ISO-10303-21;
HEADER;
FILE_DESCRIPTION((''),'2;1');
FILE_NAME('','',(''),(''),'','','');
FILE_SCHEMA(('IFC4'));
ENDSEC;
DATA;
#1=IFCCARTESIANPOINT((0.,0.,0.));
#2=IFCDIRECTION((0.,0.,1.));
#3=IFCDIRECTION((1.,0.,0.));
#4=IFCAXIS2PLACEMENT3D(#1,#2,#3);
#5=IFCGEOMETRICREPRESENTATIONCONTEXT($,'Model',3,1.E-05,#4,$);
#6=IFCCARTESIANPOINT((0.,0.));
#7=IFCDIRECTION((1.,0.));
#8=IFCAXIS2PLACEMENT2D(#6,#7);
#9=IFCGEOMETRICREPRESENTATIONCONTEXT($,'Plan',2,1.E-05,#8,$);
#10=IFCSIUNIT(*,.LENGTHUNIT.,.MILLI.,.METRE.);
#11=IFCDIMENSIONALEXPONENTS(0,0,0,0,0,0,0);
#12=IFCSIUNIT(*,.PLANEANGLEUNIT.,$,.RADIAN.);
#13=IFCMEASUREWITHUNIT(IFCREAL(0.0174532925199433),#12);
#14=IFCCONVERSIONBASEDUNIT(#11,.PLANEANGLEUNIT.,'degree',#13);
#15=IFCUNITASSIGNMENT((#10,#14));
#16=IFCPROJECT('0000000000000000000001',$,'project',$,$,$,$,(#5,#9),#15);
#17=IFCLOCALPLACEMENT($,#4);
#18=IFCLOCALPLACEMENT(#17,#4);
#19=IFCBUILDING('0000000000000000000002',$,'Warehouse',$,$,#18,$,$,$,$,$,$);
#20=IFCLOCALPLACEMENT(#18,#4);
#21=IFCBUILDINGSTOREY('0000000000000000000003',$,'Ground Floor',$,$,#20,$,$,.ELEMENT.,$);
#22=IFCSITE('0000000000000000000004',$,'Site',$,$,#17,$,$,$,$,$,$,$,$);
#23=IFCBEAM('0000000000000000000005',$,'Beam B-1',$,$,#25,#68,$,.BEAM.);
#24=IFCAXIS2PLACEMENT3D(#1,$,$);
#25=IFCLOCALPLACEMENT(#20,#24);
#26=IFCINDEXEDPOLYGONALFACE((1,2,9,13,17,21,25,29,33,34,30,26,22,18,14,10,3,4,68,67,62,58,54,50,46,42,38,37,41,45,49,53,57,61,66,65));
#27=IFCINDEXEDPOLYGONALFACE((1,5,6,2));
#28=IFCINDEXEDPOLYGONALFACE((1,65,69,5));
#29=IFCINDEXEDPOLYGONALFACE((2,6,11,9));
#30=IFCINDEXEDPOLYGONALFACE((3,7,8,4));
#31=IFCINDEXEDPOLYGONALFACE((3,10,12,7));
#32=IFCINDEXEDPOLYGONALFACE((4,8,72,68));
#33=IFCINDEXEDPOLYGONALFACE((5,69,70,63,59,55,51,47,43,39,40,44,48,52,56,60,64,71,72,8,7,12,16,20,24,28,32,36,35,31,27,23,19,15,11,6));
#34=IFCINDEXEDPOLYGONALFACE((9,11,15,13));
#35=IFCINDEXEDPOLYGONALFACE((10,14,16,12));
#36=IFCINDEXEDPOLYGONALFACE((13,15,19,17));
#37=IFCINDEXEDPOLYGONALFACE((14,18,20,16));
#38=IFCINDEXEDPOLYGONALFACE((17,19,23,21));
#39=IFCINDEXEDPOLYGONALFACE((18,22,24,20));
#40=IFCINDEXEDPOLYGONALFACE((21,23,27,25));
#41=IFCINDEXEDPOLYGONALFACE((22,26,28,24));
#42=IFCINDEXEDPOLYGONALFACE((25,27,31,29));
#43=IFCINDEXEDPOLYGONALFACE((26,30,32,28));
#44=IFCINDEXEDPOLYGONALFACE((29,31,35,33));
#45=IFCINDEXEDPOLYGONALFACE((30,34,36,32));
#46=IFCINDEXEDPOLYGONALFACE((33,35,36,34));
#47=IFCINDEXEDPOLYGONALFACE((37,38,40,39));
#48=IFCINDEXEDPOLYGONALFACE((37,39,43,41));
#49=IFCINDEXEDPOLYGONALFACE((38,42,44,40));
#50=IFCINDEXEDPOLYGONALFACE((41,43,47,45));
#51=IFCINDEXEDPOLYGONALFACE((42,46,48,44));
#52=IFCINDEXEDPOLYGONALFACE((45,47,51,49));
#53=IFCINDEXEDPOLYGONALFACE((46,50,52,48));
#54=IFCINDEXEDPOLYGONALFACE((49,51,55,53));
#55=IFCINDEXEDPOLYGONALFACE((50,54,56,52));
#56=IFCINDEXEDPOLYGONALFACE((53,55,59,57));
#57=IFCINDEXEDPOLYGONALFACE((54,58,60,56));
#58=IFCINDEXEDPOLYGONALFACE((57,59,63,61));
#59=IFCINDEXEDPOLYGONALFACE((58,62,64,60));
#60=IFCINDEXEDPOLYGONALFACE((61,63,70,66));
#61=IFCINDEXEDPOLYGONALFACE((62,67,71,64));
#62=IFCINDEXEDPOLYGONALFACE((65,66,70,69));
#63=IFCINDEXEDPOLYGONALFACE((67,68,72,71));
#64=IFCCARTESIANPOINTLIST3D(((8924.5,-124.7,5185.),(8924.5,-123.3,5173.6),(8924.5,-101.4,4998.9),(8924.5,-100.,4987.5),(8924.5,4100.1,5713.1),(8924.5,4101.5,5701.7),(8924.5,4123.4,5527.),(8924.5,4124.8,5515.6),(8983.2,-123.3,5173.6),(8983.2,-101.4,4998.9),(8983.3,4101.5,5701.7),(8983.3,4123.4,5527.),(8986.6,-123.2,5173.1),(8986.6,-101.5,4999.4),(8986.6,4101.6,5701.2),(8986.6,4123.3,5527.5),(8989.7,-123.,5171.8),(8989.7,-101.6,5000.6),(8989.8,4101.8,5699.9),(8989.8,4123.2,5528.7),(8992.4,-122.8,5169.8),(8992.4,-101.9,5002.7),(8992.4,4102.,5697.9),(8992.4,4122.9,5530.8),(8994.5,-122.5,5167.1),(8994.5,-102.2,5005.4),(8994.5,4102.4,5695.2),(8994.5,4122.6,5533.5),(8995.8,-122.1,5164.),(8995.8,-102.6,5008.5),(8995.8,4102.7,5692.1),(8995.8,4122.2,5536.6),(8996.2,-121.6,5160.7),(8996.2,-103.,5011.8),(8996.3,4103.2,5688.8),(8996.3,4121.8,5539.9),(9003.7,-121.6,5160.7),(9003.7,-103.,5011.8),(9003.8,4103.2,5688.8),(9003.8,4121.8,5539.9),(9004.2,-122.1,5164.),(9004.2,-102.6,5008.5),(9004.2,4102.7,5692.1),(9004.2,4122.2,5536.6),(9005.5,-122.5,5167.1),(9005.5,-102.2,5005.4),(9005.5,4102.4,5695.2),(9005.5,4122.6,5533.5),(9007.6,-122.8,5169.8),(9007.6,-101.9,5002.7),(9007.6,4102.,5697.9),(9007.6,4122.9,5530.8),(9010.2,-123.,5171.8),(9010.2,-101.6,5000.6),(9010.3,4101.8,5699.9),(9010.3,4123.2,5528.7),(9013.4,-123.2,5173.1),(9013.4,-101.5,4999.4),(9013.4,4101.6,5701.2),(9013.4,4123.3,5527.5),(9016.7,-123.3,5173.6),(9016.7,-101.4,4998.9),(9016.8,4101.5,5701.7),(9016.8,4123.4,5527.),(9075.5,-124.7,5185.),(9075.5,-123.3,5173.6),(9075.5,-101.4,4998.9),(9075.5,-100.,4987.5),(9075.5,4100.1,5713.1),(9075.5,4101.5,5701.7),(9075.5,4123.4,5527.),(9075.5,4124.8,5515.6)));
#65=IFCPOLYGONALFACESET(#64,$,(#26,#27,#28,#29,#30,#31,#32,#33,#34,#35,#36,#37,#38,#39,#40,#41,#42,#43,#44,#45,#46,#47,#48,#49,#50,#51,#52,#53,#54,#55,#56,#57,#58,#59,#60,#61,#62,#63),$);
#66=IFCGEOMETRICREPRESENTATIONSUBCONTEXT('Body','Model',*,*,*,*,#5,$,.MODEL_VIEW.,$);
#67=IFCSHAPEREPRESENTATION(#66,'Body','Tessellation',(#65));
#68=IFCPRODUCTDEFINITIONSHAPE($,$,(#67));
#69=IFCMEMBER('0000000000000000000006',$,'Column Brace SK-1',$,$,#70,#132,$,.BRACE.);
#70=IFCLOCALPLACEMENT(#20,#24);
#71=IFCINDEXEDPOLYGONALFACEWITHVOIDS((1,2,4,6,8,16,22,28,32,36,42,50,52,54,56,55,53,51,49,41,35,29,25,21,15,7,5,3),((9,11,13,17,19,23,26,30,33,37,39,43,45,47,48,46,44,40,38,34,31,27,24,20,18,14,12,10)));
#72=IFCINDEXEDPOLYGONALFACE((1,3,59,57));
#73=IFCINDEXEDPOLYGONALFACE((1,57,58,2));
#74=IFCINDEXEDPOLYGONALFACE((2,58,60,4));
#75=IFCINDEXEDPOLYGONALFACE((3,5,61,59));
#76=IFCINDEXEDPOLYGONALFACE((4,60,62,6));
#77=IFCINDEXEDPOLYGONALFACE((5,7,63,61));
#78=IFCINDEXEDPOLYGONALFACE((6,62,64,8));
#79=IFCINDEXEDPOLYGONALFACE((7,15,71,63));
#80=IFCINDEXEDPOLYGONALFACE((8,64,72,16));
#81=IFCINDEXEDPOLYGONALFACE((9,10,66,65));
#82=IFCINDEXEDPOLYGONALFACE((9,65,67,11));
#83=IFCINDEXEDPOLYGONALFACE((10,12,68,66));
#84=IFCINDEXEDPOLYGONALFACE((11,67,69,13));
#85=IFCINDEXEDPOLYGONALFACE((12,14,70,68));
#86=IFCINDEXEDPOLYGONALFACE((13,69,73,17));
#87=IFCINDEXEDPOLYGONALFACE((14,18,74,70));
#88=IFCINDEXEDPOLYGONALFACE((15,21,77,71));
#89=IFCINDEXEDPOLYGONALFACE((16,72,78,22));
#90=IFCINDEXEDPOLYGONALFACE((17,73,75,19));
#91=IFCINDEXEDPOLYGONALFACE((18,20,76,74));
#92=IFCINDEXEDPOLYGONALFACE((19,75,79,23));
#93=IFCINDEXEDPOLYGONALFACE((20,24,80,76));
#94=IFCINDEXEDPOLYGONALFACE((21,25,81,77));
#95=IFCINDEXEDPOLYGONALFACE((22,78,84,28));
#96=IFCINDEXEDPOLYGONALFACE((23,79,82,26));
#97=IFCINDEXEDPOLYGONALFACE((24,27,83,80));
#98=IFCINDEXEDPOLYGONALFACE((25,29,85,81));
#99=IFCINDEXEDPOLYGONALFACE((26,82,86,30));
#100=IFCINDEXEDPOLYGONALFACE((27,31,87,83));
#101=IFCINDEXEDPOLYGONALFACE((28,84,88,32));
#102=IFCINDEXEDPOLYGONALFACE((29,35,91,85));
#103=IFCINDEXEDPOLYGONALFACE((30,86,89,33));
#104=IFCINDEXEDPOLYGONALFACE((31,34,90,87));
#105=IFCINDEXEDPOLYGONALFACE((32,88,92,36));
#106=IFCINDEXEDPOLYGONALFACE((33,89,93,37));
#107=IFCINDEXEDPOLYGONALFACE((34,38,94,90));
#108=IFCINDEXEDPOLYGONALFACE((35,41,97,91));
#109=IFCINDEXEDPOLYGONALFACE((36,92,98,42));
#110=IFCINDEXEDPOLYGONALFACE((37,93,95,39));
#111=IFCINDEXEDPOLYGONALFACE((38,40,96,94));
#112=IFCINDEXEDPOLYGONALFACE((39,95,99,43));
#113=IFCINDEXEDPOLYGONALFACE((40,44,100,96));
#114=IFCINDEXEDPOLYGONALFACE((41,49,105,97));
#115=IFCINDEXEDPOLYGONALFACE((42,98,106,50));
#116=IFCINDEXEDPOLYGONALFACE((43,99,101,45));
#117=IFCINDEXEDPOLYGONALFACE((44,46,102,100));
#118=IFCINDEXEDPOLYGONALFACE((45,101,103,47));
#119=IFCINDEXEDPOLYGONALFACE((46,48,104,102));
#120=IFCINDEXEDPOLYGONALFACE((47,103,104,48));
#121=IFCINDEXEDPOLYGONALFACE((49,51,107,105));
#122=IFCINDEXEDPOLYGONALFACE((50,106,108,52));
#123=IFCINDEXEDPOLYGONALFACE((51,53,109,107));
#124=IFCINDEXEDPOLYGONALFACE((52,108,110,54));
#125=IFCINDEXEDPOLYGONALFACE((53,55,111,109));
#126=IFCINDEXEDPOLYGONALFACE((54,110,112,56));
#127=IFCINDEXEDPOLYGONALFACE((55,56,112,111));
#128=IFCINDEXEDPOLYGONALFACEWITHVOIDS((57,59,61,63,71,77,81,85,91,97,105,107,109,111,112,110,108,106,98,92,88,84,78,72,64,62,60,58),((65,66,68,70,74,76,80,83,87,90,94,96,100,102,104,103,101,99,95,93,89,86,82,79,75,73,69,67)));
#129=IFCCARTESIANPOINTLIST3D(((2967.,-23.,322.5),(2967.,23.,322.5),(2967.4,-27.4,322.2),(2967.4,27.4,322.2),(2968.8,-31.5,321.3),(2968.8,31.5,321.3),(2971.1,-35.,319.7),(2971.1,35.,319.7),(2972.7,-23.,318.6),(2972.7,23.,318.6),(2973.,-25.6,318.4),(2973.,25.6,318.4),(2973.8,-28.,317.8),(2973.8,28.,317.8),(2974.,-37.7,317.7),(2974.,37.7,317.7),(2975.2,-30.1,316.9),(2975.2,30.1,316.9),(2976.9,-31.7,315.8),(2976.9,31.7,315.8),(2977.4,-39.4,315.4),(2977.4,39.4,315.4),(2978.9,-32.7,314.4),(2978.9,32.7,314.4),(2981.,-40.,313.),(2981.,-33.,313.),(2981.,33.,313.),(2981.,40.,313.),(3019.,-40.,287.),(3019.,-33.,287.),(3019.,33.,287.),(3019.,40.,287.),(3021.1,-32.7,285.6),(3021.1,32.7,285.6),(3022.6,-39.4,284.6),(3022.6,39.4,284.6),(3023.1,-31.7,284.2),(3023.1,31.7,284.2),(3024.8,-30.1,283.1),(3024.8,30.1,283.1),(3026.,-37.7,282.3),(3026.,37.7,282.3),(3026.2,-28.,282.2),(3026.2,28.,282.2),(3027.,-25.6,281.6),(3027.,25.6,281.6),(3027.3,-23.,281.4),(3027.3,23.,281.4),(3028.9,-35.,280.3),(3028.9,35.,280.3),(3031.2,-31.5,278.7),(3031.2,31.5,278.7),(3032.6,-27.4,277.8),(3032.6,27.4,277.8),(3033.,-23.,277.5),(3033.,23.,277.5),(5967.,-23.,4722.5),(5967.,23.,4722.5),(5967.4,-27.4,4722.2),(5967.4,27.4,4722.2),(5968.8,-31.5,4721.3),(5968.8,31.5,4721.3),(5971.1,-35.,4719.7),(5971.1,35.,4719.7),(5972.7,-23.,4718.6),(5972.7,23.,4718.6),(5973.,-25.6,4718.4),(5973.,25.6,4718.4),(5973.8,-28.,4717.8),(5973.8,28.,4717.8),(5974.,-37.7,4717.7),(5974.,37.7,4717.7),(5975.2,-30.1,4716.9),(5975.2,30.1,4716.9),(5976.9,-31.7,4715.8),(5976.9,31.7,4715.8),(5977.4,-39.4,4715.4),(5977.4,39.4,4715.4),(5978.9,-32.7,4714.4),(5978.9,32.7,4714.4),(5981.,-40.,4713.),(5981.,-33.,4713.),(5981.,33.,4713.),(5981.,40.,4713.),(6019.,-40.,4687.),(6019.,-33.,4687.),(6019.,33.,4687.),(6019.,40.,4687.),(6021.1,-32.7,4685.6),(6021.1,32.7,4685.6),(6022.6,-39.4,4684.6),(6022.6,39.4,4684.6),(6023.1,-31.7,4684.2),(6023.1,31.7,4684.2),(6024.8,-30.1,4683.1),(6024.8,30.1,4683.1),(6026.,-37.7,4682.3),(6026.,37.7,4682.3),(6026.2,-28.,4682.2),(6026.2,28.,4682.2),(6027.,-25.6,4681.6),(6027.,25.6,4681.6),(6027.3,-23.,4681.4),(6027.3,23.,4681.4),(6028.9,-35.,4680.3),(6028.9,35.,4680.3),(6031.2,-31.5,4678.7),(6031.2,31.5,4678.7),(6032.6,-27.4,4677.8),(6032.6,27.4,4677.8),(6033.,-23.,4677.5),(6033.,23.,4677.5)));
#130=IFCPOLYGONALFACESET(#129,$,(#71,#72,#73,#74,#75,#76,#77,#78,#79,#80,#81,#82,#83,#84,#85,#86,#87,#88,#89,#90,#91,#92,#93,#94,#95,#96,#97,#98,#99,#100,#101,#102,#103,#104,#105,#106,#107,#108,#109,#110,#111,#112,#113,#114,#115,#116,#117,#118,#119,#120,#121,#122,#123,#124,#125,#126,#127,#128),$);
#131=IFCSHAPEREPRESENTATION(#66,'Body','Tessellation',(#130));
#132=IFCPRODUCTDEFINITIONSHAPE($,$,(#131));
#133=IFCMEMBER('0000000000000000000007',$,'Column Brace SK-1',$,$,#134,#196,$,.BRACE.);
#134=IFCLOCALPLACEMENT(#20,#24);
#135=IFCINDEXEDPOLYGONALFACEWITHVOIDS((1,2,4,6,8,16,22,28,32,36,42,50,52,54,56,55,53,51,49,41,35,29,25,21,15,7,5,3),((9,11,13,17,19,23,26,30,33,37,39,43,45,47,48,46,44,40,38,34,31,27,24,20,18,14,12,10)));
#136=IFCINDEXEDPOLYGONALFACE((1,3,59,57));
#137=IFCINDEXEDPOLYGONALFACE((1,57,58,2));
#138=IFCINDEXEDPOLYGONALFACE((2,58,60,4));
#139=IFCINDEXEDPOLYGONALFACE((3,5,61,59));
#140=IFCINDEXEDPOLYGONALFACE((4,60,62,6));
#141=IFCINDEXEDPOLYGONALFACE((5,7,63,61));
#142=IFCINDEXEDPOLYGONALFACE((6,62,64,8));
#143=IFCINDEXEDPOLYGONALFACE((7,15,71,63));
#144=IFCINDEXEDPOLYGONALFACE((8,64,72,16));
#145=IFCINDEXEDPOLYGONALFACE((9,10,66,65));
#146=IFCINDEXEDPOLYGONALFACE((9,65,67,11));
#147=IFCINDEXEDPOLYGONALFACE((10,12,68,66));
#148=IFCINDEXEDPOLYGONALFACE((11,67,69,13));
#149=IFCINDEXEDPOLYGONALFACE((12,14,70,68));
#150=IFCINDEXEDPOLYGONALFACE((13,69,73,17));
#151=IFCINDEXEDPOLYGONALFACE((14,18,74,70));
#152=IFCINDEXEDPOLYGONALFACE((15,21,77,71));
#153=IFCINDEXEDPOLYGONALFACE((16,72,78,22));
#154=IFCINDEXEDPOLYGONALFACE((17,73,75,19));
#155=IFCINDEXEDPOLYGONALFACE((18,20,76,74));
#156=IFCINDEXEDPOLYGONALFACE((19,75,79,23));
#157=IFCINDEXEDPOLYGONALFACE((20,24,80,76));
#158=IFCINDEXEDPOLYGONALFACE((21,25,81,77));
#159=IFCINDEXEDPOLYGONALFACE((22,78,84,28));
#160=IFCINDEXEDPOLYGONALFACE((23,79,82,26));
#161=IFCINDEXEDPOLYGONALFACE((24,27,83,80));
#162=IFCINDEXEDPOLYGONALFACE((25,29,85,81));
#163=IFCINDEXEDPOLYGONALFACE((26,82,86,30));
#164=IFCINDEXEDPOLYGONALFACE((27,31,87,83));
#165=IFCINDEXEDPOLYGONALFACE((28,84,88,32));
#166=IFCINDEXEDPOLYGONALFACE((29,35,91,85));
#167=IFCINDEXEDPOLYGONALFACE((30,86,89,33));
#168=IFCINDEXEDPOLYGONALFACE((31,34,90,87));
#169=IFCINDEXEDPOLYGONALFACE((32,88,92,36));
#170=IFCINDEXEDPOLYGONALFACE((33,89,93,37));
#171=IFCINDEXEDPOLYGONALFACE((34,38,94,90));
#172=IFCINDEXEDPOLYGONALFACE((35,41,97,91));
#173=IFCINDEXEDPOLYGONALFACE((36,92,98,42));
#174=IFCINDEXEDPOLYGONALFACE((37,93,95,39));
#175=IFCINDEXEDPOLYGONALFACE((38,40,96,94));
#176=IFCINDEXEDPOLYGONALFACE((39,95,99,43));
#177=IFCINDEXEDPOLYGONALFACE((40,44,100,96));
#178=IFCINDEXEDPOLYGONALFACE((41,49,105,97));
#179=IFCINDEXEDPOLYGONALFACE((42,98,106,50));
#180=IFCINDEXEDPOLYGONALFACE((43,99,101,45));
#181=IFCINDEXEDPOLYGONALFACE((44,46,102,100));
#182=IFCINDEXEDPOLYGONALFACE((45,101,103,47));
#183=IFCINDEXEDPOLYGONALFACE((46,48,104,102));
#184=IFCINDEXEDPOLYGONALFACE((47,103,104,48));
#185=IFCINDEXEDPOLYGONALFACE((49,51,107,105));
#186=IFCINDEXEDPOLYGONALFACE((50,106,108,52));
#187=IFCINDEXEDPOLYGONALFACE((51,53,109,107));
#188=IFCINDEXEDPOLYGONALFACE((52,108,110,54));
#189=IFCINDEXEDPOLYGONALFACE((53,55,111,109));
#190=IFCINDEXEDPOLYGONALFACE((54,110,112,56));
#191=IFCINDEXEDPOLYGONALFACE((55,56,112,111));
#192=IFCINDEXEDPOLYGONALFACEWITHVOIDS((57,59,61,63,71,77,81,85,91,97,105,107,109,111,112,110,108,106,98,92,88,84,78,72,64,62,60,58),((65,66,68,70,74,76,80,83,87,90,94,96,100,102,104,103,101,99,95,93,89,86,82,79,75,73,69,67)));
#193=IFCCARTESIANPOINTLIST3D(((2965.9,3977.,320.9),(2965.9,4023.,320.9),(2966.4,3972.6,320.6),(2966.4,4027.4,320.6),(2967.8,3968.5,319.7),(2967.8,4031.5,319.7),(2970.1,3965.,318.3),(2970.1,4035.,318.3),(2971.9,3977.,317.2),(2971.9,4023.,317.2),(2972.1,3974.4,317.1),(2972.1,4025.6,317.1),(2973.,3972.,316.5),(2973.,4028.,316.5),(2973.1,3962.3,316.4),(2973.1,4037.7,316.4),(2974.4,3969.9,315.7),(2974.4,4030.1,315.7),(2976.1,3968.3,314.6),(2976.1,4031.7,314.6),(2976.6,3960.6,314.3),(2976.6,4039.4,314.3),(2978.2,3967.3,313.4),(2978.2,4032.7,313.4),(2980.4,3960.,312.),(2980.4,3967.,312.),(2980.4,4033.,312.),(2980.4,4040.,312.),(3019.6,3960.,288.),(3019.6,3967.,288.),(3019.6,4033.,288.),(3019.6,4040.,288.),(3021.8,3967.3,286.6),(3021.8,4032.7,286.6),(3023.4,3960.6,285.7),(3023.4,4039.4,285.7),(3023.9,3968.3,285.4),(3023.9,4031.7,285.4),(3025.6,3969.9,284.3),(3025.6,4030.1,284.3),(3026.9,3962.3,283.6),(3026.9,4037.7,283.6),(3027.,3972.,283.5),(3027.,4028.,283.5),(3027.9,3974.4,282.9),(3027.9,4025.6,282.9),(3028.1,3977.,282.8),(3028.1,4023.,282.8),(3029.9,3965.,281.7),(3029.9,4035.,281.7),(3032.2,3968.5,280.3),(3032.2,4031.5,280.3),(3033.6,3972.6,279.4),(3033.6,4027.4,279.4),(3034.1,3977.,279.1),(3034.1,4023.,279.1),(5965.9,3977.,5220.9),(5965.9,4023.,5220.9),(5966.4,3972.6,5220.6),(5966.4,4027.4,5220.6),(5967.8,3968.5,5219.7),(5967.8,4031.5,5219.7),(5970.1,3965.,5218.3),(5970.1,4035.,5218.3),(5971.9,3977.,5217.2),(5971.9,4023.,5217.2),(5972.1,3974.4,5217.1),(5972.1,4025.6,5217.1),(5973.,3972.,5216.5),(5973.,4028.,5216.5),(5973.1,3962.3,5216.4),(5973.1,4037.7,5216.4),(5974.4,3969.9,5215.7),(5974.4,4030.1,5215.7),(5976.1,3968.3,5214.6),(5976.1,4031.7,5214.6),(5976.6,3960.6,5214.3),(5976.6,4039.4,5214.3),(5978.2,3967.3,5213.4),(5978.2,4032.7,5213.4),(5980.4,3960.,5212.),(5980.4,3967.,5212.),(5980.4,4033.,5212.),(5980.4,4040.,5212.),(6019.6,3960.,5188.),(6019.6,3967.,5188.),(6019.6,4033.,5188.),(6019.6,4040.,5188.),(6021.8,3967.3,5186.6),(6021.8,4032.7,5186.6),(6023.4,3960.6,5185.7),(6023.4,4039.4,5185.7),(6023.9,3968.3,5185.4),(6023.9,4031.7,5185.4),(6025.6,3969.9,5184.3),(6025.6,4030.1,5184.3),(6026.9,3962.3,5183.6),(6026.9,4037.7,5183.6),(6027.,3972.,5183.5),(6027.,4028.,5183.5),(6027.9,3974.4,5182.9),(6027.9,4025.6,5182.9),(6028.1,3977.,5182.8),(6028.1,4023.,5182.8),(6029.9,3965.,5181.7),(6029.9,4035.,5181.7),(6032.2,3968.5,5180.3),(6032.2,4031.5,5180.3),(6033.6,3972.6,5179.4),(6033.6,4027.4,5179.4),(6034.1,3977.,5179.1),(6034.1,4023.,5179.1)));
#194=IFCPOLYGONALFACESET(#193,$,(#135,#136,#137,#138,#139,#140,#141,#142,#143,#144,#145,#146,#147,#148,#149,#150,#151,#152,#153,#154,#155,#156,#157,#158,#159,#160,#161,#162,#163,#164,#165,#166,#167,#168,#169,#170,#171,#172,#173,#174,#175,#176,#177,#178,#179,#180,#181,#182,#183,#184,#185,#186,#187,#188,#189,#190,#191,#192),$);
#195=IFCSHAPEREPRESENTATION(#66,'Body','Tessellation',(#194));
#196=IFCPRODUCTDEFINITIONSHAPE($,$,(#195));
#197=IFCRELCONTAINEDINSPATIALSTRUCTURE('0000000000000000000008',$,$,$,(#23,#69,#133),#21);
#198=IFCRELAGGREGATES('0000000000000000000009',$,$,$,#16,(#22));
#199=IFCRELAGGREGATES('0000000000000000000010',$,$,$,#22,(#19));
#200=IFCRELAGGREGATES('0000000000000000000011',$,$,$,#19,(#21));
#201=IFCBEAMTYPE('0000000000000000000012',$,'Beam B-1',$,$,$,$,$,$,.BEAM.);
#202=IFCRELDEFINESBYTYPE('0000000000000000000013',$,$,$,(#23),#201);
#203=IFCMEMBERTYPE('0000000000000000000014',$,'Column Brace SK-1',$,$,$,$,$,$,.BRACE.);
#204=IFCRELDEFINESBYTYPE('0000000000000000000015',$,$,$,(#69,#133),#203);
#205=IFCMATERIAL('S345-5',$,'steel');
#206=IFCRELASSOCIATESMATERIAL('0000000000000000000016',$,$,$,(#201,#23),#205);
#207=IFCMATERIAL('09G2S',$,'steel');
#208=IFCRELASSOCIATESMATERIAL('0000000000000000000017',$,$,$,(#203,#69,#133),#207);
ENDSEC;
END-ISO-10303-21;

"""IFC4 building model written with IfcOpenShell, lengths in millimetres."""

from ifc_helpers import new_model, entity, si_unit, converted_unit, frame, origin_with_axes, origin_2d_with_axis, place, context, subcontext, project, spatial, hollow_rectangle, i_section, extrude, material, material_profile, profile_set, profile_usage, type_object, element, save


model = new_model("IFC4")

# Units and contexts
model_context = context("Model", 3, precision=1e-05, world=origin_with_axes())
plan_context = context("Plan", 2, precision=1e-05, world=origin_2d_with_axis())
body_context = subcontext(model_context, "Body", "Model", "MODEL_VIEW")
ifc_project = project(units=[si_unit("LENGTHUNIT", "METRE", prefix="MILLI"), converted_unit("PLANEANGLEUNIT", "degree", entity("IfcReal", 0.0174532925199433), si_unit("PLANEANGLEUNIT", "RADIAN"), dimensions=[0, 0, 0, 0, 0, 0, 0])], contexts=[model_context, plan_context])

# Site, building, storey
site_placement = place(None, origin_with_axes())
site = spatial("IfcSite", under=ifc_project, at=site_placement, Name="Site")
building_placement = place(site_placement, origin_with_axes())
building = spatial("IfcBuilding", under=site, at=building_placement, Name="Warehouse")
storey_placement = place(building_placement, origin_with_axes())
storey = spatial("IfcBuildingStorey", under=building, at=storey_placement, Name="Ground Floor", CompositionType="ELEMENT")

# Shared definitions
ifc_material_1 = material(Name="S345-5", Category="steel")

# Beam
ifc_material_profile_1 = material_profile(ifc_material_1, i_section(OverallWidth=151.0, OverallDepth=199.0, WebThickness=7.5, FlangeThickness=11.5, FilletRadius=13.0, FlangeEdgeRadius=0.0, FlangeSlope=0.0))
ifc_profile_set_1 = profile_set([ifc_material_profile_1], Name="I20H2_S345-5")
beam_type_1 = type_object("IfcBeamType", Name="Beam B-1", PredefinedType="BEAM", material=ifc_profile_set_1)
ifc_profile_usage_1 = profile_usage(ifc_profile_set_1, cardinal=2)
beam_1_placement = place(storey_placement, frame((9000.0, -100.0, 4987.5), z_axis=(0.0, 0.992278, 0.124035), x_axis=(-1.0, 0.0, 0.0)))
element("IfcBeam", 1, at=beam_1_placement, inside=storey, type_object=beam_type_1, material=ifc_profile_usage_1, Name="Beam B-1", PredefinedType="BEAM", context=body_context, shape_type="SweptSolid", body=[
    extrude(i_section(OverallWidth=151.0, OverallDepth=199.0, WebThickness=7.5, FlangeThickness=11.5, FilletRadius=13.0, FlangeEdgeRadius=0.0, FlangeSlope=0.0), frame((0.0, 99.5, 0.0), z_axis=(0.0, 0.0, 1.0), x_axis=(1.0, 0.0, 0.0)), (0.0, 0.0, 1.0), 4257.7),
])

# Members
ifc_material_2 = material(Name="09G2S", Category="steel")
ifc_material_profile_2 = material_profile(ifc_material_2, hollow_rectangle(XDim=80.0, YDim=80.0, WallThickness=7.0, InnerFilletRadius=10.0, OuterFilletRadius=17.0))
ifc_profile_set_2 = profile_set([ifc_material_profile_2], Name="PK80x7_09G2S")
ifc_profile_usage_2 = profile_usage(ifc_profile_set_2, cardinal=5)
member_type_1 = type_object("IfcMemberType", Name="Column Brace SK-1", PredefinedType="BRACE", material=ifc_profile_set_2)
member_1_placement = place(storey_placement, frame((3000.0, 0.0, 300.0), z_axis=(0.563337, 0.0, 0.826227), x_axis=(0.0, 1.0, 0.0)))
element("IfcMember", 2, at=member_1_placement, inside=storey, type_object=member_type_1, material=ifc_profile_usage_2, Name="Column Brace SK-1", PredefinedType="BRACE", context=body_context, shape_type="SweptSolid", body=[
    extrude(hollow_rectangle(XDim=80.0, YDim=80.0, WallThickness=7.0, InnerFilletRadius=10.0, OuterFilletRadius=17.0), origin_with_axes(), (0.0, 0.0, 1.0), 5325.4),
])
ifc_profile_usage_3 = profile_usage(ifc_profile_set_2, cardinal=5)
member_2_placement = place(storey_placement, frame((3000.0, 4000.0, 300.0), z_axis=(0.522154, 0.0, 0.852851), x_axis=(0.0, 1.0, 0.0)))
element("IfcMember", 3, at=member_2_placement, inside=storey, type_object=member_type_1, material=ifc_profile_usage_3, Name="Column Brace SK-1", PredefinedType="BRACE", context=body_context, shape_type="SweptSolid", body=[
    extrude(hollow_rectangle(XDim=80.0, YDim=80.0, WallThickness=7.0, InnerFilletRadius=10.0, OuterFilletRadius=17.0), origin_with_axes(), (0.0, 0.0, 1.0), 5745.4),
])

save(model, "model.ifc")
